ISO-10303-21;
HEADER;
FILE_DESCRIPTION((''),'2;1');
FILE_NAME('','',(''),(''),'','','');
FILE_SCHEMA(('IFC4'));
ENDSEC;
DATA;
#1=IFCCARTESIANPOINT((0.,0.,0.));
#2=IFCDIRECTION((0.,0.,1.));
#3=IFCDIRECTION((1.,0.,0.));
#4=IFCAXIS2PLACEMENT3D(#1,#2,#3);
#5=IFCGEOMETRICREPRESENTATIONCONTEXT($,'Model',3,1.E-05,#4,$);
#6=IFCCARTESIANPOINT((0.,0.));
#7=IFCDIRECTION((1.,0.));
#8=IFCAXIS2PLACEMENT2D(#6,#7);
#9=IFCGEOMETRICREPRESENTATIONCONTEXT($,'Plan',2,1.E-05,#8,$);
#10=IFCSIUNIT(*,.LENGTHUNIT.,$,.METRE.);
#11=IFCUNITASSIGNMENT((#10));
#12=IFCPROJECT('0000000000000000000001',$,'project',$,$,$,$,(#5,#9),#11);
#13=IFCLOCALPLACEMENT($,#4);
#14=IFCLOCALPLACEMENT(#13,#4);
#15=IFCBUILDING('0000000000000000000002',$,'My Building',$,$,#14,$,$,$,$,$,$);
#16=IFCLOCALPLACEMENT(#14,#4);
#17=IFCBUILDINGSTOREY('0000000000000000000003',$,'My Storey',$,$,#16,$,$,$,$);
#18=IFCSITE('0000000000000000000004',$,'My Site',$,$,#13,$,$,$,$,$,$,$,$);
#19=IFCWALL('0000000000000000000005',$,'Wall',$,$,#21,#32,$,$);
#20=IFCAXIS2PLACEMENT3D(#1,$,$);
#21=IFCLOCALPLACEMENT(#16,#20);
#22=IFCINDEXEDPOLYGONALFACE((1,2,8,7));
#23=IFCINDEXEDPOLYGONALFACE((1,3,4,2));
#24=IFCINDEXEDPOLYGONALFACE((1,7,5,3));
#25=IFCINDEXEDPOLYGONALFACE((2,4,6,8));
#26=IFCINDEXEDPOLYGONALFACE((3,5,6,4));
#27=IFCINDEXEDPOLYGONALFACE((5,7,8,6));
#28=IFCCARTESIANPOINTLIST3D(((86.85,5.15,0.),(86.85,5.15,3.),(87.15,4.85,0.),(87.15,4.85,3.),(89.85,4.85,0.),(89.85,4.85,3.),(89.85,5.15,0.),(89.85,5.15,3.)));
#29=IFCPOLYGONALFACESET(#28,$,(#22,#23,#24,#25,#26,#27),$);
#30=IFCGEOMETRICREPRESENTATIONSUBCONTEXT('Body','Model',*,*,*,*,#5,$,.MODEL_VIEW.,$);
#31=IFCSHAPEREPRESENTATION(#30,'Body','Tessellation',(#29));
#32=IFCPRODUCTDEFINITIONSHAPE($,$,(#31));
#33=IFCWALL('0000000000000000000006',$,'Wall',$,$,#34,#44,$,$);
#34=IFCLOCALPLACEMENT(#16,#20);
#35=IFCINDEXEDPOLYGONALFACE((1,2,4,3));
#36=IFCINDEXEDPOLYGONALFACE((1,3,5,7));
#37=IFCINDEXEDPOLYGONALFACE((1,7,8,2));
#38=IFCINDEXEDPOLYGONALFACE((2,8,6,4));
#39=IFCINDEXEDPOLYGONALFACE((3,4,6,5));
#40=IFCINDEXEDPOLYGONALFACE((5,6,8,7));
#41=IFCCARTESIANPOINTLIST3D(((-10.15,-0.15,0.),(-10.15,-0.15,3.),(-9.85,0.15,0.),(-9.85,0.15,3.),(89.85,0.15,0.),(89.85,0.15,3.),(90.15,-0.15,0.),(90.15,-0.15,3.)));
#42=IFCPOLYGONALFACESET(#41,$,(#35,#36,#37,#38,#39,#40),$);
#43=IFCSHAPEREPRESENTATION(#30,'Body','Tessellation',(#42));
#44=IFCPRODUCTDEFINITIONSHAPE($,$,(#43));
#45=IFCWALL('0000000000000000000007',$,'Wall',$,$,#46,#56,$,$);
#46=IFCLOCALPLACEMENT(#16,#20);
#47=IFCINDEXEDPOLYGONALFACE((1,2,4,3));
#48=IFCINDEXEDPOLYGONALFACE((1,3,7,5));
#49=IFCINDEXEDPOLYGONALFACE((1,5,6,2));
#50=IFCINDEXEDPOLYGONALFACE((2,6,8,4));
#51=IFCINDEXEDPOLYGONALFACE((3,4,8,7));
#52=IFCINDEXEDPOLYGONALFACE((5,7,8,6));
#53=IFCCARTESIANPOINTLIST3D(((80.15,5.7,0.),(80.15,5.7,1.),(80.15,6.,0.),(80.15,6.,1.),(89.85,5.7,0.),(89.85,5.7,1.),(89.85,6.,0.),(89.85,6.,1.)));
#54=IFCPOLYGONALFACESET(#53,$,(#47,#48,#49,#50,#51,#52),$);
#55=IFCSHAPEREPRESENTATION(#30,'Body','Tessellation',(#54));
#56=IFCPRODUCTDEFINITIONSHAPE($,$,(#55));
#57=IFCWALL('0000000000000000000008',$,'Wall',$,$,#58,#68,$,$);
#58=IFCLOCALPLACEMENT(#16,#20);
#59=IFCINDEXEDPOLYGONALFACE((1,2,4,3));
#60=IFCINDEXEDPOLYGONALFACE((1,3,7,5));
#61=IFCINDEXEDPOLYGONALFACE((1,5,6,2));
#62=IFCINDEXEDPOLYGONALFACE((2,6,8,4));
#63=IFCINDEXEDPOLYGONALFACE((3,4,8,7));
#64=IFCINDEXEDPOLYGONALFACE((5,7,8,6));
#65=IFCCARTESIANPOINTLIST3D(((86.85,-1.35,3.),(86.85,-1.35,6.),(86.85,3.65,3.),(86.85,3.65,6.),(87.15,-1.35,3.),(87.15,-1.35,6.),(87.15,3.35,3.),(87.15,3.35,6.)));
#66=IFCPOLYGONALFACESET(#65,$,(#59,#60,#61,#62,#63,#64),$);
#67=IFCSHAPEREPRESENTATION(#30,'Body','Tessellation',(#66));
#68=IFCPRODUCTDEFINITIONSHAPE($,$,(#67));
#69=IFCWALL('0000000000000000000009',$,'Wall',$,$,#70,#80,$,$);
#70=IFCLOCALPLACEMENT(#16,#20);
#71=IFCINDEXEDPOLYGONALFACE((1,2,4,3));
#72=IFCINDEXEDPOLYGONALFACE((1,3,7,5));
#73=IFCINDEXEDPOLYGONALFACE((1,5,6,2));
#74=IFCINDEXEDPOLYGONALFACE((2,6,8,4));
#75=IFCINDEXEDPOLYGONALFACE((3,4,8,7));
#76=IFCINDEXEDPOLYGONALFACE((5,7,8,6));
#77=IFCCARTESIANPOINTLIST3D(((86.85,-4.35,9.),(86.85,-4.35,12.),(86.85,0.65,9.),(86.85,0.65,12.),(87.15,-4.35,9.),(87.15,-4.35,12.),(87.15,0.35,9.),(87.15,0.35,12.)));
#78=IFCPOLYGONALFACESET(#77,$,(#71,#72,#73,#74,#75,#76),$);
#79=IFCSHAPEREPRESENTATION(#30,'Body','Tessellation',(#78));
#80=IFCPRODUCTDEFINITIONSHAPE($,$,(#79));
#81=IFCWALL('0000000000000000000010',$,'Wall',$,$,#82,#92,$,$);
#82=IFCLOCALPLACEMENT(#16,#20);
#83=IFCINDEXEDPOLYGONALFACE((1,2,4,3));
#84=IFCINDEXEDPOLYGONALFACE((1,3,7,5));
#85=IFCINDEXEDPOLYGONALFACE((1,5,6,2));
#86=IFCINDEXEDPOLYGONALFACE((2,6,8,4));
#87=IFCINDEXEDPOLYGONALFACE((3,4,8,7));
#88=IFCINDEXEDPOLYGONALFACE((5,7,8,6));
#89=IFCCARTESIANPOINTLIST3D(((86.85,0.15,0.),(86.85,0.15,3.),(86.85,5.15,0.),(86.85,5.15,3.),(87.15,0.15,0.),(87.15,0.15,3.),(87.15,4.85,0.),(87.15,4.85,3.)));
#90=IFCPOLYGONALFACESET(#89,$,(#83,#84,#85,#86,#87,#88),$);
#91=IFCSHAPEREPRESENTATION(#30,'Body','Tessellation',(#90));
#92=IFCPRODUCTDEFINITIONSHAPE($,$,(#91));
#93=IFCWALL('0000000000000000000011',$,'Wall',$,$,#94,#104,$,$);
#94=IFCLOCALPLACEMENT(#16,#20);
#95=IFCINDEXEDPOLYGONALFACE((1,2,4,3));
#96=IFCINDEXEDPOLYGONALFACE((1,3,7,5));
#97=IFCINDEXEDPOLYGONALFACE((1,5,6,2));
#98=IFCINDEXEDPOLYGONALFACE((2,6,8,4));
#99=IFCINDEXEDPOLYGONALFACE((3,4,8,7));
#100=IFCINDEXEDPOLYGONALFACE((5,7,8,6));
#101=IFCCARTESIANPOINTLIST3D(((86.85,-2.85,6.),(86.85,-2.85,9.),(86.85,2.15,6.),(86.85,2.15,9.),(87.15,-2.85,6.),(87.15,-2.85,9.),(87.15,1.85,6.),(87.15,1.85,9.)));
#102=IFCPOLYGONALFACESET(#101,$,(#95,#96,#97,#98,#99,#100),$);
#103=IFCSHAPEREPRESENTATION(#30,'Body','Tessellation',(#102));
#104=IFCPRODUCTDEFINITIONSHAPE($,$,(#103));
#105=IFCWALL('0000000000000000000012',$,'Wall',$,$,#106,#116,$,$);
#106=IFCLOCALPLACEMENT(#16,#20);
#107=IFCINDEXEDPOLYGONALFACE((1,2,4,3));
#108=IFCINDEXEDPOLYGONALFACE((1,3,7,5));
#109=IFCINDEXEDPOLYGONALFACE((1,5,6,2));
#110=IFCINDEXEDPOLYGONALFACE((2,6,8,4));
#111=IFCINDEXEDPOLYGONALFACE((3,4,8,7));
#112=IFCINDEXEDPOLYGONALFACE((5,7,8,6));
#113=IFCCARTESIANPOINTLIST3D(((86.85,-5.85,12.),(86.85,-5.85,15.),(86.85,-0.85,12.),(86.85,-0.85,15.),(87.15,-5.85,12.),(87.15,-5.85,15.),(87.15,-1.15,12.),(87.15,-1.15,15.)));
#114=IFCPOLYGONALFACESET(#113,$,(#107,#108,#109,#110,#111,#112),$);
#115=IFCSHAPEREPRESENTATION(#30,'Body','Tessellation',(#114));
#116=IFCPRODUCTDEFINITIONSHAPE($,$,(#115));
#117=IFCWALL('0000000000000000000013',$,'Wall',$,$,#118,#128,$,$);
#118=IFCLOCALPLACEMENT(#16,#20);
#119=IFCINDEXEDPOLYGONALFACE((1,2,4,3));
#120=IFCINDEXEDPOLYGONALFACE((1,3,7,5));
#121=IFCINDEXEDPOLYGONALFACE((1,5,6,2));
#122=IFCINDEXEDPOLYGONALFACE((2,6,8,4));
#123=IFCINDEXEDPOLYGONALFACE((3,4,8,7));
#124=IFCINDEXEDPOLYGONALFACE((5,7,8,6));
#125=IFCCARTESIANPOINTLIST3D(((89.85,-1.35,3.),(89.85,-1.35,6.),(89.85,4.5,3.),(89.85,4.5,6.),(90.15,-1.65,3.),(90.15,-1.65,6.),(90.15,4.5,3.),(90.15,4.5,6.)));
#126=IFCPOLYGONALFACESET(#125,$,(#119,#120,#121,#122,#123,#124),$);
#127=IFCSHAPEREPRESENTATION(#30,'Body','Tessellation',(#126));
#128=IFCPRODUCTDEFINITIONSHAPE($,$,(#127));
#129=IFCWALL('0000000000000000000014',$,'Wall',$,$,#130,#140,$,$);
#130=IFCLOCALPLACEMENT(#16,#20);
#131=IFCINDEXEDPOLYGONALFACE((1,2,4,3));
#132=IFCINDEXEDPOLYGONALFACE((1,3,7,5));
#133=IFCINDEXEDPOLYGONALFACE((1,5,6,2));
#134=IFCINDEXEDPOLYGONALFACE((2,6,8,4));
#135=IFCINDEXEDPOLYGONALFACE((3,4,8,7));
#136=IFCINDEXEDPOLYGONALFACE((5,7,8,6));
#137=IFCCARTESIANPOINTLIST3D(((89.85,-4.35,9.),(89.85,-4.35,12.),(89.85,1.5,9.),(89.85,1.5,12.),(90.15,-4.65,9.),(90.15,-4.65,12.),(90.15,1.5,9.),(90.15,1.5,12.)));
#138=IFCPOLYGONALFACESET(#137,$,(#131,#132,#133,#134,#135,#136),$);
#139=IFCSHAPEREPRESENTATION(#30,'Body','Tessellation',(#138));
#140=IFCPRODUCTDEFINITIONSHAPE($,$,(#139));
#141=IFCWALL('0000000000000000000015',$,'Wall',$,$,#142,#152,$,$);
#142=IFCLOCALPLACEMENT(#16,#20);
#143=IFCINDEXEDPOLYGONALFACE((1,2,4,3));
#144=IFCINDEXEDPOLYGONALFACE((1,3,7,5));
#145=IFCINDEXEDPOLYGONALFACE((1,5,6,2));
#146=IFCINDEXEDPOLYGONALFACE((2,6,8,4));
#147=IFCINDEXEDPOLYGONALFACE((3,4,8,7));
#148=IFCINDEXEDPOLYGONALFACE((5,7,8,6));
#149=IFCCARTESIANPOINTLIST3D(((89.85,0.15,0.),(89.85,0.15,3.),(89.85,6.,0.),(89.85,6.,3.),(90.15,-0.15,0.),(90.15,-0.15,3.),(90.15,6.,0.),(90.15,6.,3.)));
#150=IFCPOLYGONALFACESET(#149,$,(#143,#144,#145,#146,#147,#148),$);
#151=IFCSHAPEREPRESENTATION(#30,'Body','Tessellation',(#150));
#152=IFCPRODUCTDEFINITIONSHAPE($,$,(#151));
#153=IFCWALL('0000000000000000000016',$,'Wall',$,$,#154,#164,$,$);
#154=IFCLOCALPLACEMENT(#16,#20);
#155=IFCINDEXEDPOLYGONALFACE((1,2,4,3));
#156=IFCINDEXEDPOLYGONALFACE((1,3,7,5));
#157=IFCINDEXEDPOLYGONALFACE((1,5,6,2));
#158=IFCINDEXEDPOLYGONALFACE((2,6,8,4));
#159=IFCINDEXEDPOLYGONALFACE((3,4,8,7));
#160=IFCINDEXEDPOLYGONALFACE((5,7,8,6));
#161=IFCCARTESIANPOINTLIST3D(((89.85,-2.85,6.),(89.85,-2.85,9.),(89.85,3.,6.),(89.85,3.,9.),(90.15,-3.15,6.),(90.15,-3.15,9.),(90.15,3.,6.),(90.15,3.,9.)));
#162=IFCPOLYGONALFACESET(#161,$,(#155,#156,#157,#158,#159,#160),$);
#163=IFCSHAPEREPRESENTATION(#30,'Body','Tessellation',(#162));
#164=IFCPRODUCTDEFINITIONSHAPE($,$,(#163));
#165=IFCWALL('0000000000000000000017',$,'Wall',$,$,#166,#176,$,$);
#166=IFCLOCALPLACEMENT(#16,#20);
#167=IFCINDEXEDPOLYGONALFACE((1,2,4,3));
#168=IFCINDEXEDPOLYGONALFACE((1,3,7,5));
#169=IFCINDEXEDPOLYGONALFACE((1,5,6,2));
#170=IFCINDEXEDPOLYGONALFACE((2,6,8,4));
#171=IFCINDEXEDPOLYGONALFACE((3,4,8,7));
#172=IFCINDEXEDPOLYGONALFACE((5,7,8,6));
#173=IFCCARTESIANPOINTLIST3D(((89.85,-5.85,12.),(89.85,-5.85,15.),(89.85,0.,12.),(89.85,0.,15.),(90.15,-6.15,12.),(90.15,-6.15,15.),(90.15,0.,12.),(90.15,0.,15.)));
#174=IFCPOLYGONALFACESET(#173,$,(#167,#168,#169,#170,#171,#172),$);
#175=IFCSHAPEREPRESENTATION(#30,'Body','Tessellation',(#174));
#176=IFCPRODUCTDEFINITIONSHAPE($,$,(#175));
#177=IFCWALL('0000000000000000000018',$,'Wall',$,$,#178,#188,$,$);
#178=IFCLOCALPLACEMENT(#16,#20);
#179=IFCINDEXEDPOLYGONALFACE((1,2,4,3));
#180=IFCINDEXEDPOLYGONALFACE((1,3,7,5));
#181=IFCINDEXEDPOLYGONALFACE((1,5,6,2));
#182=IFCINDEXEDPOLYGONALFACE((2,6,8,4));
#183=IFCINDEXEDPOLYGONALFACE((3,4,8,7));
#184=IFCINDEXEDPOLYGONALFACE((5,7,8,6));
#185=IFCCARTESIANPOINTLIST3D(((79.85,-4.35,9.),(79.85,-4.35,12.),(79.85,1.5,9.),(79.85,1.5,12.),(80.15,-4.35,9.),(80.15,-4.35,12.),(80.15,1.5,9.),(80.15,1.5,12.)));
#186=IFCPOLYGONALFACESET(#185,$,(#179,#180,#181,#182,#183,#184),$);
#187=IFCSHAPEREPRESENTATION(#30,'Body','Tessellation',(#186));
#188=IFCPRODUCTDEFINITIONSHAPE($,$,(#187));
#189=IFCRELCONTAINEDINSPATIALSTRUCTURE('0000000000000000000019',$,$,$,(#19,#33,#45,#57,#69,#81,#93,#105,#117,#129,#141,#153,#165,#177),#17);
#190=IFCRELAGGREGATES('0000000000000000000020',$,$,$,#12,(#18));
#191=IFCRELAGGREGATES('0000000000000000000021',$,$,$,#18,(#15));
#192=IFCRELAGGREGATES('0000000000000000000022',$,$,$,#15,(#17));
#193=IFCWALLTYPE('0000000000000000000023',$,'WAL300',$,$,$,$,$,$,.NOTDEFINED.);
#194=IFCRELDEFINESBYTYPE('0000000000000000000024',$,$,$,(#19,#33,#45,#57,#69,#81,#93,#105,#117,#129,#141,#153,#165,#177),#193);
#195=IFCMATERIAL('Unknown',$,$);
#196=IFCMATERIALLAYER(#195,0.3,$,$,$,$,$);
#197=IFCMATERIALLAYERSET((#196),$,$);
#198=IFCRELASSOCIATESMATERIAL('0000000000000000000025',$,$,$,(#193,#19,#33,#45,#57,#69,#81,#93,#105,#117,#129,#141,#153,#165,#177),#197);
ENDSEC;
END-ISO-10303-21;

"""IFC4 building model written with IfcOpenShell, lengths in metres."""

from ifc_helpers import new_model, si_unit, frame, origin_with_axes, origin_2d_with_axis, place, context, subcontext, project, spatial, line, indexed_curve, outline, extrude, material, layer, layer_set, layer_usage, type_object, element, save


model = new_model("IFC4")

# Units and contexts
model_context = context("Model", 3, precision=1e-05, world=origin_with_axes())
plan_context = context("Plan", 2, precision=1e-05, world=origin_2d_with_axis())
body_context = subcontext(model_context, "Body", "Model", "MODEL_VIEW")
ifc_project = project(units=[si_unit("LENGTHUNIT", "METRE")], contexts=[model_context, plan_context])

# Site, building, storey
site_placement = place(None, origin_with_axes())
site = spatial("IfcSite", under=ifc_project, at=site_placement, Name="My Site")
building_placement = place(site_placement, origin_with_axes())
building = spatial("IfcBuilding", under=site, at=building_placement, Name="My Building")
storey_placement = place(building_placement, origin_with_axes())
storey = spatial("IfcBuildingStorey", under=building, at=storey_placement, Name="My Storey")

# Walls
ifc_material = material(Name="Unknown")
ifc_layer = layer(ifc_material, 0.3)
ifc_layer_set = layer_set([ifc_layer])
ifc_layer_usage_1 = layer_usage(ifc_layer_set, "AXIS2", "POSITIVE", -0.15)
wall_type = type_object("IfcWallType", Name="WAL300", PredefinedType="NOTDEFINED", material=ifc_layer_set)
wall_1_placement = place(storey_placement, frame((87.0, 5.0, 0.0), z_axis=(0.0, 0.0, 1.0), x_axis=(1.0, 0.0, 0.0)))
element("IfcWall", 1, at=wall_1_placement, inside=storey, type_object=wall_type, material=ifc_layer_usage_1, Name="Wall", context=body_context, shape_type="SweptSolid", body=[
    extrude(outline(indexed_curve([(0.15, -0.15), (-0.15, 0.15), (2.85, 0.15), (2.85, -0.15)], segments=[line(1, 2, 3, 4, 1)])), origin_with_axes(), (0.0, 0.0, 1.0), 3.0),
])
ifc_layer_usage_2 = layer_usage(ifc_layer_set, "AXIS2", "POSITIVE", -0.15)
wall_2_placement = place(storey_placement, frame((90.0, 0.0, 0.0), z_axis=(0.0, 0.0, 1.0), x_axis=(-1.0, 0.0, 0.0)))
element("IfcWall", 2, at=wall_2_placement, inside=storey, type_object=wall_type, material=ifc_layer_usage_2, Name="Wall", context=body_context, shape_type="SweptSolid", body=[
    extrude(outline(indexed_curve([(0.15, -0.15), (-0.15, 0.15), (100.15, 0.15), (99.85, -0.15)], segments=[line(1, 2, 3, 4, 1)])), origin_with_axes(), (0.0, 0.0, 1.0), 3.0),
])
ifc_layer_usage_3 = layer_usage(ifc_layer_set, "AXIS2", "POSITIVE", -0.3)
wall_3_placement = place(storey_placement, frame((80.15, 6.0, 0.0), z_axis=(0.0, 0.0, 1.0), x_axis=(1.0, 0.0, 0.0)))
element("IfcWall", 3, at=wall_3_placement, inside=storey, type_object=wall_type, material=ifc_layer_usage_3, Name="Wall", context=body_context, shape_type="SweptSolid", body=[
    extrude(outline(indexed_curve([(0.0, -0.3), (0.0, 0.0), (9.7, 0.0), (9.7, -0.3)], segments=[line(1, 2, 3, 4, 1)])), origin_with_axes(), (0.0, 0.0, 1.0), 1.0),
])
ifc_layer_usage_4 = layer_usage(ifc_layer_set, "AXIS2", "POSITIVE", -0.15)
wall_4_placement = place(storey_placement, frame((87.0, 3.5, 3.0), z_axis=(0.0, 0.0, 1.0), x_axis=(0.0, -1.0, 0.0)))
element("IfcWall", 4, at=wall_4_placement, inside=storey, type_object=wall_type, material=ifc_layer_usage_4, Name="Wall", context=body_context, shape_type="SweptSolid", body=[
    extrude(outline(indexed_curve([(-0.15, -0.15), (0.15, 0.15), (4.85, 0.15), (4.85, -0.15)], segments=[line(1, 2, 3, 4, 1)])), origin_with_axes(), (0.0, 0.0, 1.0), 3.0),
])
ifc_layer_usage_5 = layer_usage(ifc_layer_set, "AXIS2", "POSITIVE", -0.15)
wall_5_placement = place(storey_placement, frame((87.0, 0.5, 9.0), z_axis=(0.0, 0.0, 1.0), x_axis=(0.0, -1.0, 0.0)))
element("IfcWall", 5, at=wall_5_placement, inside=storey, type_object=wall_type, material=ifc_layer_usage_5, Name="Wall", context=body_context, shape_type="SweptSolid", body=[
    extrude(outline(indexed_curve([(-0.15, -0.15), (0.15, 0.15), (4.85, 0.15), (4.85, -0.15)], segments=[line(1, 2, 3, 4, 1)])), origin_with_axes(), (0.0, 0.0, 1.0), 3.0),
])
ifc_layer_usage_6 = layer_usage(ifc_layer_set, "AXIS2", "POSITIVE", -0.15)
wall_6_placement = place(storey_placement, frame((87.0, 5.0, 0.0), z_axis=(0.0, 0.0, 1.0), x_axis=(0.0, -1.0, 0.0)))
element("IfcWall", 6, at=wall_6_placement, inside=storey, type_object=wall_type, material=ifc_layer_usage_6, Name="Wall", context=body_context, shape_type="SweptSolid", body=[
    extrude(outline(indexed_curve([(-0.15, -0.15), (0.15, 0.15), (4.85, 0.15), (4.85, -0.15)], segments=[line(1, 2, 3, 4, 1)])), origin_with_axes(), (0.0, 0.0, 1.0), 3.0),
])
ifc_layer_usage_7 = layer_usage(ifc_layer_set, "AXIS2", "POSITIVE", -0.15)
wall_7_placement = place(storey_placement, frame((87.0, 2.0, 6.0), z_axis=(0.0, 0.0, 1.0), x_axis=(0.0, -1.0, 0.0)))
element("IfcWall", 7, at=wall_7_placement, inside=storey, type_object=wall_type, material=ifc_layer_usage_7, Name="Wall", context=body_context, shape_type="SweptSolid", body=[
    extrude(outline(indexed_curve([(-0.15, -0.15), (0.15, 0.15), (4.85, 0.15), (4.85, -0.15)], segments=[line(1, 2, 3, 4, 1)])), origin_with_axes(), (0.0, 0.0, 1.0), 3.0),
])
ifc_layer_usage_8 = layer_usage(ifc_layer_set, "AXIS2", "POSITIVE", -0.15)
wall_8_placement = place(storey_placement, frame((87.0, -1.0, 12.0), z_axis=(0.0, 0.0, 1.0), x_axis=(0.0, -1.0, 0.0)))
element("IfcWall", 8, at=wall_8_placement, inside=storey, type_object=wall_type, material=ifc_layer_usage_8, Name="Wall", context=body_context, shape_type="SweptSolid", body=[
    extrude(outline(indexed_curve([(-0.15, -0.15), (0.15, 0.15), (4.85, 0.15), (4.85, -0.15)], segments=[line(1, 2, 3, 4, 1)])), origin_with_axes(), (0.0, 0.0, 1.0), 3.0),
])
ifc_layer_usage_9 = layer_usage(ifc_layer_set, "AXIS2", "POSITIVE", -0.15)
wall_9_placement = place(storey_placement, frame((90.0, 4.5, 3.0), z_axis=(0.0, 0.0, 1.0), x_axis=(0.0, -1.0, 0.0)))
element("IfcWall", 9, at=wall_9_placement, inside=storey, type_object=wall_type, material=ifc_layer_usage_9, Name="Wall", context=body_context, shape_type="SweptSolid", body=[
    extrude(outline(indexed_curve([(0.0, -0.15), (0.0, 0.15), (6.15, 0.15), (5.85, -0.15)], segments=[line(1, 2, 3, 4, 1)])), origin_with_axes(), (0.0, 0.0, 1.0), 3.0),
])
ifc_layer_usage_10 = layer_usage(ifc_layer_set, "AXIS2", "POSITIVE", -0.15)
wall_10_placement = place(storey_placement, frame((90.0, 1.5, 9.0), z_axis=(0.0, 0.0, 1.0), x_axis=(0.0, -1.0, 0.0)))
element("IfcWall", 10, at=wall_10_placement, inside=storey, type_object=wall_type, material=ifc_layer_usage_10, Name="Wall", context=body_context, shape_type="SweptSolid", body=[
    extrude(outline(indexed_curve([(0.0, -0.15), (0.0, 0.15), (6.15, 0.15), (5.85, -0.15)], segments=[line(1, 2, 3, 4, 1)])), origin_with_axes(), (0.0, 0.0, 1.0), 3.0),
])
ifc_layer_usage_11 = layer_usage(ifc_layer_set, "AXIS2", "POSITIVE", -0.15)
wall_11_placement = place(storey_placement, frame((90.0, 6.0, 0.0), z_axis=(0.0, 0.0, 1.0), x_axis=(0.0, -1.0, 0.0)))
element("IfcWall", 11, at=wall_11_placement, inside=storey, type_object=wall_type, material=ifc_layer_usage_11, Name="Wall", context=body_context, shape_type="SweptSolid", body=[
    extrude(outline(indexed_curve([(0.0, -0.15), (0.0, 0.15), (6.15, 0.15), (5.85, -0.15)], segments=[line(1, 2, 3, 4, 1)])), origin_with_axes(), (0.0, 0.0, 1.0), 3.0),
])
ifc_layer_usage_12 = layer_usage(ifc_layer_set, "AXIS2", "POSITIVE", -0.15)
wall_12_placement = place(storey_placement, frame((90.0, 3.0, 6.0), z_axis=(0.0, 0.0, 1.0), x_axis=(0.0, -1.0, 0.0)))
element("IfcWall", 12, at=wall_12_placement, inside=storey, type_object=wall_type, material=ifc_layer_usage_12, Name="Wall", context=body_context, shape_type="SweptSolid", body=[
    extrude(outline(indexed_curve([(0.0, -0.15), (0.0, 0.15), (6.15, 0.15), (5.85, -0.15)], segments=[line(1, 2, 3, 4, 1)])), origin_with_axes(), (0.0, 0.0, 1.0), 3.0),
])
ifc_layer_usage_13 = layer_usage(ifc_layer_set, "AXIS2", "POSITIVE", -0.15)
wall_13_placement = place(storey_placement, frame((90.0, 0.0, 12.0), z_axis=(0.0, 0.0, 1.0), x_axis=(0.0, -1.0, 0.0)))
element("IfcWall", 13, at=wall_13_placement, inside=storey, type_object=wall_type, material=ifc_layer_usage_13, Name="Wall", context=body_context, shape_type="SweptSolid", body=[
    extrude(outline(indexed_curve([(0.0, -0.15), (0.0, 0.15), (6.15, 0.15), (5.85, -0.15)], segments=[line(1, 2, 3, 4, 1)])), origin_with_axes(), (0.0, 0.0, 1.0), 3.0),
])
ifc_layer_usage_14 = layer_usage(ifc_layer_set, "AXIS2", "POSITIVE", -0.15)
wall_14_placement = place(storey_placement, frame((80.0, -4.5, 9.0), z_axis=(0.0, 0.0, 1.0), x_axis=(0.0, 1.0, 0.0)))
element("IfcWall", 14, at=wall_14_placement, inside=storey, type_object=wall_type, material=ifc_layer_usage_14, Name="Wall", context=body_context, shape_type="SweptSolid", body=[
    extrude(outline(indexed_curve([(0.15, -0.15), (0.15, 0.15), (6.0, 0.15), (6.0, -0.15)], segments=[line(1, 2, 3, 4, 1)])), origin_with_axes(), (0.0, 0.0, 1.0), 3.0),
])

save(model, "model.ifc")
